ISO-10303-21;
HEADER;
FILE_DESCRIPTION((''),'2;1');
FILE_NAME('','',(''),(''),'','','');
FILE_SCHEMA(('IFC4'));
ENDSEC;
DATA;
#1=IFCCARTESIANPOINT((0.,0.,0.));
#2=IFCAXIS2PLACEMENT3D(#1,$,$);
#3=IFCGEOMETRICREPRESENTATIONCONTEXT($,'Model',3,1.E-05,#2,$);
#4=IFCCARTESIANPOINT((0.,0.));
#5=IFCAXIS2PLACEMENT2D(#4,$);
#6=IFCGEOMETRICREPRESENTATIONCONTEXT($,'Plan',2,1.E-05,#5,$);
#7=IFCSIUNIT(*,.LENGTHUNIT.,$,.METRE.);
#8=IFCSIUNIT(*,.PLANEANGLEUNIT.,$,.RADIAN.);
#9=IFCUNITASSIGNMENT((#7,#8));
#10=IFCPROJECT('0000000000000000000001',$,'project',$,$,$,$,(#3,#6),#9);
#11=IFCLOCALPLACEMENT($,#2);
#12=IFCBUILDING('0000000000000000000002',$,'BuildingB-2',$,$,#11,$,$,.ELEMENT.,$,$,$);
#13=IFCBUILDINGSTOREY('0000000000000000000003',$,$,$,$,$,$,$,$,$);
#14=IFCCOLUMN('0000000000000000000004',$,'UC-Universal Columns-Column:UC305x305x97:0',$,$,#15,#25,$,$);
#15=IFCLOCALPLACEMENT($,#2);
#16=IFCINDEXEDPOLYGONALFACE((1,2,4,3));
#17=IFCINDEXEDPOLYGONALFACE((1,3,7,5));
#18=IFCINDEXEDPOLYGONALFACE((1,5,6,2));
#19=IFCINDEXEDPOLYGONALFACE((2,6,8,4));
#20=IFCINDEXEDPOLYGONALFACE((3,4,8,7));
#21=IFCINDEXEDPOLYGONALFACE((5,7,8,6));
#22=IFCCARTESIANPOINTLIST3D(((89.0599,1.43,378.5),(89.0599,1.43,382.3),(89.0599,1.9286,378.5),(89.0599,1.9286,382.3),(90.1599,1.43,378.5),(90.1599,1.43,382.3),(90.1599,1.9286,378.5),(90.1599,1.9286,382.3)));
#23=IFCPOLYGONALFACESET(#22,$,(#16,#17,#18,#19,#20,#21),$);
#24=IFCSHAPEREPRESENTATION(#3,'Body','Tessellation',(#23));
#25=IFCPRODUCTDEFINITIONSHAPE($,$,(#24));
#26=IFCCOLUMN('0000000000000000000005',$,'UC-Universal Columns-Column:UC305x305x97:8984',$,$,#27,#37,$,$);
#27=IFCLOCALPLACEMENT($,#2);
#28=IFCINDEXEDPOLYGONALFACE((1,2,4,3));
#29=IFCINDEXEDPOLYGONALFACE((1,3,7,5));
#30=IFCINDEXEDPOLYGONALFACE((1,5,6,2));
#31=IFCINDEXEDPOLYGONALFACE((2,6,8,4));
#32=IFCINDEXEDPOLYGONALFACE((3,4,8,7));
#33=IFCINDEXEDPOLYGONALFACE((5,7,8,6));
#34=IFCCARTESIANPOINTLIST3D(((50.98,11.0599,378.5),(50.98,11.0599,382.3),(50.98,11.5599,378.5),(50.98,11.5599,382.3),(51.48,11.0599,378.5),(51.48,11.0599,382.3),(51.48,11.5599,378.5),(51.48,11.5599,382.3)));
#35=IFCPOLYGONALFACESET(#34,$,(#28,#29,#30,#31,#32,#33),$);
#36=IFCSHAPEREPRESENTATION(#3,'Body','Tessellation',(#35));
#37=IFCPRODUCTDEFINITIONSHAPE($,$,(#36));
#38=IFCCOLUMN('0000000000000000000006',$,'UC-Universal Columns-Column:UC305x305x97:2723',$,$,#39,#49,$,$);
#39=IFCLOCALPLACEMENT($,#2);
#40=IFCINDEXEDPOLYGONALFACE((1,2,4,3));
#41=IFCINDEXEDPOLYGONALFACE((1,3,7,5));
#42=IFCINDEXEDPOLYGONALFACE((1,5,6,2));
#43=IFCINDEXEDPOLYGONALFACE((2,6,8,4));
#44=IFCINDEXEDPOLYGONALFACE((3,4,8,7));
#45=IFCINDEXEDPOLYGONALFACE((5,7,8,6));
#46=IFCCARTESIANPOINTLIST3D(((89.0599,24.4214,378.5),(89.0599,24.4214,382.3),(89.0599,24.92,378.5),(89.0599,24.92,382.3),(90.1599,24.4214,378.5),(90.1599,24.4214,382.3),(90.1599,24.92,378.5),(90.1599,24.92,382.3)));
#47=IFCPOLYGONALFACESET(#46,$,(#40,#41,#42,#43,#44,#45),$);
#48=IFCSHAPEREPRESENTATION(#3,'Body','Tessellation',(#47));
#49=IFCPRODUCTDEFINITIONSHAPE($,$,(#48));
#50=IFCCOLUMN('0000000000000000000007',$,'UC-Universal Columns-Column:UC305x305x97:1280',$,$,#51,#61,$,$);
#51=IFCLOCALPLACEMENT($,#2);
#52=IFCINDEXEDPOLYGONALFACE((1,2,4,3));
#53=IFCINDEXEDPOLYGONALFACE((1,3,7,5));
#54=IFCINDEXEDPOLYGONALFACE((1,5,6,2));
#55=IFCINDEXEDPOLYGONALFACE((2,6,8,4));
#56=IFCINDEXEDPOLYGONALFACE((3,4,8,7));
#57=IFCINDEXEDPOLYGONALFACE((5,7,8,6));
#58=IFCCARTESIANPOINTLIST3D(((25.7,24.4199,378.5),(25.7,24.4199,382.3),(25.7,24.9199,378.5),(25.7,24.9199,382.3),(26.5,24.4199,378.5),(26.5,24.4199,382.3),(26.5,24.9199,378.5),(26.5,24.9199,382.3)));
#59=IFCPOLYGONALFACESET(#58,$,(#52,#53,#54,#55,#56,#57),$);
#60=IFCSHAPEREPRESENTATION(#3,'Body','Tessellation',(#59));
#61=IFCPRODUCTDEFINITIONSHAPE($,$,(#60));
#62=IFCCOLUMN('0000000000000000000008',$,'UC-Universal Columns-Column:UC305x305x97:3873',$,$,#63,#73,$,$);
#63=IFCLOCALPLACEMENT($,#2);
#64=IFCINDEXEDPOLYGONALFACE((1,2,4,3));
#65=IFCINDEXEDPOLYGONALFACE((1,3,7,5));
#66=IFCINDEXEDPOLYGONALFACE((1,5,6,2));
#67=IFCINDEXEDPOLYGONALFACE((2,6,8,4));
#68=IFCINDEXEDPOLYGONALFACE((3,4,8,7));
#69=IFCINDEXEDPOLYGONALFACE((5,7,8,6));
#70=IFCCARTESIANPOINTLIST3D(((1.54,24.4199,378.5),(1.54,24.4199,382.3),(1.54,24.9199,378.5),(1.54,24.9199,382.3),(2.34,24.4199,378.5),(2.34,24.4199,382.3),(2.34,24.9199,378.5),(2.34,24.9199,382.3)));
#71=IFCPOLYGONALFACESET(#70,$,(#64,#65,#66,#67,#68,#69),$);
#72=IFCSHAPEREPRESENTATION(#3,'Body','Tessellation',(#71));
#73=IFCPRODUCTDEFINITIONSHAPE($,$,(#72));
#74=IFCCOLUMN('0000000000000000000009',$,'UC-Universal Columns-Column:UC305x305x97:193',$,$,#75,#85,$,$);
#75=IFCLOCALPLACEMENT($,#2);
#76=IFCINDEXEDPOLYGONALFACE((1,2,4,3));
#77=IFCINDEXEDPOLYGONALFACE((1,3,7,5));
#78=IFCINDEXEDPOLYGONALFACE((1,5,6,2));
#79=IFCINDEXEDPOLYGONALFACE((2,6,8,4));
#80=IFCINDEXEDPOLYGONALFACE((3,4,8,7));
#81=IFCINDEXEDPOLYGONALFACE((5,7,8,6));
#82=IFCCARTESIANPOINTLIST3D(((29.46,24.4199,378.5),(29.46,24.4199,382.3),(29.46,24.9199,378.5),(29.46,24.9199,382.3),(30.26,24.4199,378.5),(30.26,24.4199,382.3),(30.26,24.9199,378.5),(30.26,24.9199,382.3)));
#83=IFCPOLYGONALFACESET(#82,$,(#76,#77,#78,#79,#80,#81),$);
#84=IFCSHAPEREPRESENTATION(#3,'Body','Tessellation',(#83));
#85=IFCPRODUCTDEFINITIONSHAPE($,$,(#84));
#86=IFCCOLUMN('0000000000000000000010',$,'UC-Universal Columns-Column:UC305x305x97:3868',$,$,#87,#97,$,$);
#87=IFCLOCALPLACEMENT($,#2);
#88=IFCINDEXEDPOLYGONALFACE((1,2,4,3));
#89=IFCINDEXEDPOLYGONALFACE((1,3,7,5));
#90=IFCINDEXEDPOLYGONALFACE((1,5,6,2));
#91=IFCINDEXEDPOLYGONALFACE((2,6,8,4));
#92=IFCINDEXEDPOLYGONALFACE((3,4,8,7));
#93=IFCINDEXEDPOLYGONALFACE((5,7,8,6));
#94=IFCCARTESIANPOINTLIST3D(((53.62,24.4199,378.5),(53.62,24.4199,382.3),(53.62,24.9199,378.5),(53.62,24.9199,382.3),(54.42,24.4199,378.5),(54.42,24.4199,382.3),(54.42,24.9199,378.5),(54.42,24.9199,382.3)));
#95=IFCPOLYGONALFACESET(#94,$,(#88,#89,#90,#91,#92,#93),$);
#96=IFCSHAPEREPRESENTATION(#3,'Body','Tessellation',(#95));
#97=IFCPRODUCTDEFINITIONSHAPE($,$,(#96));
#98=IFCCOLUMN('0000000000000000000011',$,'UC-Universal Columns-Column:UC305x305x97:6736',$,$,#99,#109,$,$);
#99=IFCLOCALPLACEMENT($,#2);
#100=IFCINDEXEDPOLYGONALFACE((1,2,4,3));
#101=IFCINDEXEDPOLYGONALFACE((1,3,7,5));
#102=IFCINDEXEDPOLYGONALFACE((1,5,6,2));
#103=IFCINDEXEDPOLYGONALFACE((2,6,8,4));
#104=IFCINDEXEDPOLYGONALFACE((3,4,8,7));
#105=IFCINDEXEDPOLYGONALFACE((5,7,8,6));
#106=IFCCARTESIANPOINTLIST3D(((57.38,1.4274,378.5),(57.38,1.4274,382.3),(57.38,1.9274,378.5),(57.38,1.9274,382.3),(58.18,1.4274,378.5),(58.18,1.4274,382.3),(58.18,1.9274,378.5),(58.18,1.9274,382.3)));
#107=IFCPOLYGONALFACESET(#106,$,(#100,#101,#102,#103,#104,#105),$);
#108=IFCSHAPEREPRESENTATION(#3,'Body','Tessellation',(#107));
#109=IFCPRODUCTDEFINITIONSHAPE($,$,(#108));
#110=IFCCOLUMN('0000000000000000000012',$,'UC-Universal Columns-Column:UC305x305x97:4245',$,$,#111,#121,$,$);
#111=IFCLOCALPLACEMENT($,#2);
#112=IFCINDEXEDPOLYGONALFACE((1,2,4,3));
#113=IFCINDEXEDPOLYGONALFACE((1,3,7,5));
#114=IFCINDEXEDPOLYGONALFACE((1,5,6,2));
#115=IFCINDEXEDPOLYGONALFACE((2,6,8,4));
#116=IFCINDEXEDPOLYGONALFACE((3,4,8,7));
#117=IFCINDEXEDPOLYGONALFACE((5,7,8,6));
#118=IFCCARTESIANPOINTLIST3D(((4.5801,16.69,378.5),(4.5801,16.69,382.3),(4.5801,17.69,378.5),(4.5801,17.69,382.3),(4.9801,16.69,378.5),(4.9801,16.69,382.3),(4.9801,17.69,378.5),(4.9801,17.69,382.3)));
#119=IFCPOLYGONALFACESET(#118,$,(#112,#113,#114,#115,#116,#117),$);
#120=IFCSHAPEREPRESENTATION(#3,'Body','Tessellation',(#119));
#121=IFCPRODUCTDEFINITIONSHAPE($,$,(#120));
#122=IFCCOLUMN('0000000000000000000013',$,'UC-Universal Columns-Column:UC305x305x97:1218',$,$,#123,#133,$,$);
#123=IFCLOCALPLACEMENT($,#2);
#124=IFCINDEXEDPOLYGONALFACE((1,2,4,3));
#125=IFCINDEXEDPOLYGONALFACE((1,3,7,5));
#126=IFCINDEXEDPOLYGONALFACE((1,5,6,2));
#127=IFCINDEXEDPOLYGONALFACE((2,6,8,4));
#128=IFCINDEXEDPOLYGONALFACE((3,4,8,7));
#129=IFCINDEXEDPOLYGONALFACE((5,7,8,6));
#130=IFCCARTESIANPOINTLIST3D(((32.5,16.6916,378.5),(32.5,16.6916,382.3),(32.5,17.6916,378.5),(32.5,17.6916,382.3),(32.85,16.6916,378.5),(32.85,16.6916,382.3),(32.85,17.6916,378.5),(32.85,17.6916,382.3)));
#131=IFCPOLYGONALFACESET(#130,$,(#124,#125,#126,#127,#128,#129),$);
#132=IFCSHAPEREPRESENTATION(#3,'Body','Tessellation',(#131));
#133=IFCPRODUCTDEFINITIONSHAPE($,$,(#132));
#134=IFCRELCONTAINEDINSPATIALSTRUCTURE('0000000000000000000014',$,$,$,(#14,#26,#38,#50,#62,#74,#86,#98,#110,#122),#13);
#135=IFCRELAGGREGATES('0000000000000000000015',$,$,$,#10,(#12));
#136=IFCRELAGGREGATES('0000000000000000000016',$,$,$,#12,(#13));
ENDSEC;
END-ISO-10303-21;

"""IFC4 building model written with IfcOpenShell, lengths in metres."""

from ifc_helpers import new_model, si_unit, origin, origin_2d, place, context, project, spatial, polyline, outline, extrude, element, save


model = new_model("IFC4")

# Units and contexts
model_context = context("Model", 3, precision=1e-05, world=origin())
plan_context = context("Plan", 2, precision=1e-05, world=origin_2d())
ifc_project = project(units=[si_unit("LENGTHUNIT", "METRE"), si_unit("PLANEANGLEUNIT", "RADIAN")], contexts=[model_context, plan_context])

# Building, storey
building_placement = place(None, origin())
building = spatial("IfcBuilding", under=ifc_project, at=building_placement, Name="BuildingB-2", CompositionType="ELEMENT")
storey = spatial("IfcBuildingStorey", under=building)

# Columns
element("IfcColumn", 1, inside=storey, Name="UC-Universal Columns-Column:UC305x305x97:0", context=model_context, shape_type="SweptSolid", body=[
    extrude(outline(polyline([(90.1599, 1.43, 382.3), (89.0599, 1.43, 382.3), (89.0599, 1.9286, 382.3), (90.1599, 1.9286, 382.3), (90.1599, 1.43, 382.3)])), None, (0.0, 0.0, -1.0), 3.8),
])
element("IfcColumn", 2, inside=storey, Name="UC-Universal Columns-Column:UC305x305x97:8984", context=model_context, shape_type="SweptSolid", body=[
    extrude(outline(polyline([(50.98, 11.0599, 382.3), (51.48, 11.0599, 382.3), (51.48, 11.5599, 382.3), (50.98, 11.5599, 382.3), (50.98, 11.0599, 382.3)])), None, (0.0, 0.0, -1.0), 3.8),
])
element("IfcColumn", 3, inside=storey, Name="UC-Universal Columns-Column:UC305x305x97:2723", context=model_context, shape_type="SweptSolid", body=[
    extrude(outline(polyline([(90.1599, 24.4214, 382.3), (89.0599, 24.4214, 382.3), (89.0599, 24.92, 382.3), (90.1599, 24.92, 382.3), (90.1599, 24.4214, 382.3)])), None, (0.0, 0.0, -1.0), 3.8),
])
element("IfcColumn", 4, inside=storey, Name="UC-Universal Columns-Column:UC305x305x97:1280", context=model_context, shape_type="SweptSolid", body=[
    extrude(outline(polyline([(25.7, 24.4199, 382.3), (26.5, 24.4199, 382.3), (26.5, 24.9199, 382.3), (25.7, 24.9199, 382.3), (25.7, 24.4199, 382.3)])), None, (0.0, 0.0, -1.0), 3.8),
])
element("IfcColumn", 5, inside=storey, Name="UC-Universal Columns-Column:UC305x305x97:3873", context=model_context, shape_type="SweptSolid", body=[
    extrude(outline(polyline([(1.54, 24.4199, 382.3), (2.34, 24.4199, 382.3), (2.34, 24.9199, 382.3), (1.54, 24.9199, 382.3), (1.54, 24.4199, 382.3)])), None, (0.0, 0.0, -1.0), 3.8),
])
element("IfcColumn", 6, inside=storey, Name="UC-Universal Columns-Column:UC305x305x97:193", context=model_context, shape_type="SweptSolid", body=[
    extrude(outline(polyline([(30.26, 24.4199, 382.3), (29.46, 24.4199, 382.3), (29.46, 24.9199, 382.3), (30.26, 24.9199, 382.3), (30.26, 24.4199, 382.3)])), None, (0.0, 0.0, -1.0), 3.8),
])
element("IfcColumn", 7, inside=storey, Name="UC-Universal Columns-Column:UC305x305x97:3868", context=model_context, shape_type="SweptSolid", body=[
    extrude(outline(polyline([(54.42, 24.4199, 382.3), (53.62, 24.4199, 382.3), (53.62, 24.9199, 382.3), (54.42, 24.9199, 382.3), (54.42, 24.4199, 382.3)])), None, (0.0, 0.0, -1.0), 3.8),
])
element("IfcColumn", 8, inside=storey, Name="UC-Universal Columns-Column:UC305x305x97:6736", context=model_context, shape_type="SweptSolid", body=[
    extrude(outline(polyline([(57.38, 1.4274, 382.3), (58.18, 1.4274, 382.3), (58.18, 1.9274, 382.3), (57.38, 1.9274, 382.3), (57.38, 1.4274, 382.3)])), None, (0.0, 0.0, -1.0), 3.8),
])
element("IfcColumn", 9, inside=storey, Name="UC-Universal Columns-Column:UC305x305x97:4245", context=model_context, shape_type="SweptSolid", body=[
    extrude(outline(polyline([(4.5801, 17.69, 382.3), (4.9801, 17.69, 382.3), (4.9801, 16.69, 382.3), (4.5801, 16.69, 382.3), (4.5801, 17.69, 382.3)])), None, (0.0, 0.0, -1.0), 3.8),
])
element("IfcColumn", 10, inside=storey, Name="UC-Universal Columns-Column:UC305x305x97:1218", context=model_context, shape_type="SweptSolid", body=[
    extrude(outline(polyline([(32.5, 17.6916, 382.3), (32.85, 17.6916, 382.3), (32.85, 16.6916, 382.3), (32.5, 16.6916, 382.3), (32.5, 17.6916, 382.3)])), None, (0.0, 0.0, -1.0), 3.8),
])

save(model, "model.ifc")
